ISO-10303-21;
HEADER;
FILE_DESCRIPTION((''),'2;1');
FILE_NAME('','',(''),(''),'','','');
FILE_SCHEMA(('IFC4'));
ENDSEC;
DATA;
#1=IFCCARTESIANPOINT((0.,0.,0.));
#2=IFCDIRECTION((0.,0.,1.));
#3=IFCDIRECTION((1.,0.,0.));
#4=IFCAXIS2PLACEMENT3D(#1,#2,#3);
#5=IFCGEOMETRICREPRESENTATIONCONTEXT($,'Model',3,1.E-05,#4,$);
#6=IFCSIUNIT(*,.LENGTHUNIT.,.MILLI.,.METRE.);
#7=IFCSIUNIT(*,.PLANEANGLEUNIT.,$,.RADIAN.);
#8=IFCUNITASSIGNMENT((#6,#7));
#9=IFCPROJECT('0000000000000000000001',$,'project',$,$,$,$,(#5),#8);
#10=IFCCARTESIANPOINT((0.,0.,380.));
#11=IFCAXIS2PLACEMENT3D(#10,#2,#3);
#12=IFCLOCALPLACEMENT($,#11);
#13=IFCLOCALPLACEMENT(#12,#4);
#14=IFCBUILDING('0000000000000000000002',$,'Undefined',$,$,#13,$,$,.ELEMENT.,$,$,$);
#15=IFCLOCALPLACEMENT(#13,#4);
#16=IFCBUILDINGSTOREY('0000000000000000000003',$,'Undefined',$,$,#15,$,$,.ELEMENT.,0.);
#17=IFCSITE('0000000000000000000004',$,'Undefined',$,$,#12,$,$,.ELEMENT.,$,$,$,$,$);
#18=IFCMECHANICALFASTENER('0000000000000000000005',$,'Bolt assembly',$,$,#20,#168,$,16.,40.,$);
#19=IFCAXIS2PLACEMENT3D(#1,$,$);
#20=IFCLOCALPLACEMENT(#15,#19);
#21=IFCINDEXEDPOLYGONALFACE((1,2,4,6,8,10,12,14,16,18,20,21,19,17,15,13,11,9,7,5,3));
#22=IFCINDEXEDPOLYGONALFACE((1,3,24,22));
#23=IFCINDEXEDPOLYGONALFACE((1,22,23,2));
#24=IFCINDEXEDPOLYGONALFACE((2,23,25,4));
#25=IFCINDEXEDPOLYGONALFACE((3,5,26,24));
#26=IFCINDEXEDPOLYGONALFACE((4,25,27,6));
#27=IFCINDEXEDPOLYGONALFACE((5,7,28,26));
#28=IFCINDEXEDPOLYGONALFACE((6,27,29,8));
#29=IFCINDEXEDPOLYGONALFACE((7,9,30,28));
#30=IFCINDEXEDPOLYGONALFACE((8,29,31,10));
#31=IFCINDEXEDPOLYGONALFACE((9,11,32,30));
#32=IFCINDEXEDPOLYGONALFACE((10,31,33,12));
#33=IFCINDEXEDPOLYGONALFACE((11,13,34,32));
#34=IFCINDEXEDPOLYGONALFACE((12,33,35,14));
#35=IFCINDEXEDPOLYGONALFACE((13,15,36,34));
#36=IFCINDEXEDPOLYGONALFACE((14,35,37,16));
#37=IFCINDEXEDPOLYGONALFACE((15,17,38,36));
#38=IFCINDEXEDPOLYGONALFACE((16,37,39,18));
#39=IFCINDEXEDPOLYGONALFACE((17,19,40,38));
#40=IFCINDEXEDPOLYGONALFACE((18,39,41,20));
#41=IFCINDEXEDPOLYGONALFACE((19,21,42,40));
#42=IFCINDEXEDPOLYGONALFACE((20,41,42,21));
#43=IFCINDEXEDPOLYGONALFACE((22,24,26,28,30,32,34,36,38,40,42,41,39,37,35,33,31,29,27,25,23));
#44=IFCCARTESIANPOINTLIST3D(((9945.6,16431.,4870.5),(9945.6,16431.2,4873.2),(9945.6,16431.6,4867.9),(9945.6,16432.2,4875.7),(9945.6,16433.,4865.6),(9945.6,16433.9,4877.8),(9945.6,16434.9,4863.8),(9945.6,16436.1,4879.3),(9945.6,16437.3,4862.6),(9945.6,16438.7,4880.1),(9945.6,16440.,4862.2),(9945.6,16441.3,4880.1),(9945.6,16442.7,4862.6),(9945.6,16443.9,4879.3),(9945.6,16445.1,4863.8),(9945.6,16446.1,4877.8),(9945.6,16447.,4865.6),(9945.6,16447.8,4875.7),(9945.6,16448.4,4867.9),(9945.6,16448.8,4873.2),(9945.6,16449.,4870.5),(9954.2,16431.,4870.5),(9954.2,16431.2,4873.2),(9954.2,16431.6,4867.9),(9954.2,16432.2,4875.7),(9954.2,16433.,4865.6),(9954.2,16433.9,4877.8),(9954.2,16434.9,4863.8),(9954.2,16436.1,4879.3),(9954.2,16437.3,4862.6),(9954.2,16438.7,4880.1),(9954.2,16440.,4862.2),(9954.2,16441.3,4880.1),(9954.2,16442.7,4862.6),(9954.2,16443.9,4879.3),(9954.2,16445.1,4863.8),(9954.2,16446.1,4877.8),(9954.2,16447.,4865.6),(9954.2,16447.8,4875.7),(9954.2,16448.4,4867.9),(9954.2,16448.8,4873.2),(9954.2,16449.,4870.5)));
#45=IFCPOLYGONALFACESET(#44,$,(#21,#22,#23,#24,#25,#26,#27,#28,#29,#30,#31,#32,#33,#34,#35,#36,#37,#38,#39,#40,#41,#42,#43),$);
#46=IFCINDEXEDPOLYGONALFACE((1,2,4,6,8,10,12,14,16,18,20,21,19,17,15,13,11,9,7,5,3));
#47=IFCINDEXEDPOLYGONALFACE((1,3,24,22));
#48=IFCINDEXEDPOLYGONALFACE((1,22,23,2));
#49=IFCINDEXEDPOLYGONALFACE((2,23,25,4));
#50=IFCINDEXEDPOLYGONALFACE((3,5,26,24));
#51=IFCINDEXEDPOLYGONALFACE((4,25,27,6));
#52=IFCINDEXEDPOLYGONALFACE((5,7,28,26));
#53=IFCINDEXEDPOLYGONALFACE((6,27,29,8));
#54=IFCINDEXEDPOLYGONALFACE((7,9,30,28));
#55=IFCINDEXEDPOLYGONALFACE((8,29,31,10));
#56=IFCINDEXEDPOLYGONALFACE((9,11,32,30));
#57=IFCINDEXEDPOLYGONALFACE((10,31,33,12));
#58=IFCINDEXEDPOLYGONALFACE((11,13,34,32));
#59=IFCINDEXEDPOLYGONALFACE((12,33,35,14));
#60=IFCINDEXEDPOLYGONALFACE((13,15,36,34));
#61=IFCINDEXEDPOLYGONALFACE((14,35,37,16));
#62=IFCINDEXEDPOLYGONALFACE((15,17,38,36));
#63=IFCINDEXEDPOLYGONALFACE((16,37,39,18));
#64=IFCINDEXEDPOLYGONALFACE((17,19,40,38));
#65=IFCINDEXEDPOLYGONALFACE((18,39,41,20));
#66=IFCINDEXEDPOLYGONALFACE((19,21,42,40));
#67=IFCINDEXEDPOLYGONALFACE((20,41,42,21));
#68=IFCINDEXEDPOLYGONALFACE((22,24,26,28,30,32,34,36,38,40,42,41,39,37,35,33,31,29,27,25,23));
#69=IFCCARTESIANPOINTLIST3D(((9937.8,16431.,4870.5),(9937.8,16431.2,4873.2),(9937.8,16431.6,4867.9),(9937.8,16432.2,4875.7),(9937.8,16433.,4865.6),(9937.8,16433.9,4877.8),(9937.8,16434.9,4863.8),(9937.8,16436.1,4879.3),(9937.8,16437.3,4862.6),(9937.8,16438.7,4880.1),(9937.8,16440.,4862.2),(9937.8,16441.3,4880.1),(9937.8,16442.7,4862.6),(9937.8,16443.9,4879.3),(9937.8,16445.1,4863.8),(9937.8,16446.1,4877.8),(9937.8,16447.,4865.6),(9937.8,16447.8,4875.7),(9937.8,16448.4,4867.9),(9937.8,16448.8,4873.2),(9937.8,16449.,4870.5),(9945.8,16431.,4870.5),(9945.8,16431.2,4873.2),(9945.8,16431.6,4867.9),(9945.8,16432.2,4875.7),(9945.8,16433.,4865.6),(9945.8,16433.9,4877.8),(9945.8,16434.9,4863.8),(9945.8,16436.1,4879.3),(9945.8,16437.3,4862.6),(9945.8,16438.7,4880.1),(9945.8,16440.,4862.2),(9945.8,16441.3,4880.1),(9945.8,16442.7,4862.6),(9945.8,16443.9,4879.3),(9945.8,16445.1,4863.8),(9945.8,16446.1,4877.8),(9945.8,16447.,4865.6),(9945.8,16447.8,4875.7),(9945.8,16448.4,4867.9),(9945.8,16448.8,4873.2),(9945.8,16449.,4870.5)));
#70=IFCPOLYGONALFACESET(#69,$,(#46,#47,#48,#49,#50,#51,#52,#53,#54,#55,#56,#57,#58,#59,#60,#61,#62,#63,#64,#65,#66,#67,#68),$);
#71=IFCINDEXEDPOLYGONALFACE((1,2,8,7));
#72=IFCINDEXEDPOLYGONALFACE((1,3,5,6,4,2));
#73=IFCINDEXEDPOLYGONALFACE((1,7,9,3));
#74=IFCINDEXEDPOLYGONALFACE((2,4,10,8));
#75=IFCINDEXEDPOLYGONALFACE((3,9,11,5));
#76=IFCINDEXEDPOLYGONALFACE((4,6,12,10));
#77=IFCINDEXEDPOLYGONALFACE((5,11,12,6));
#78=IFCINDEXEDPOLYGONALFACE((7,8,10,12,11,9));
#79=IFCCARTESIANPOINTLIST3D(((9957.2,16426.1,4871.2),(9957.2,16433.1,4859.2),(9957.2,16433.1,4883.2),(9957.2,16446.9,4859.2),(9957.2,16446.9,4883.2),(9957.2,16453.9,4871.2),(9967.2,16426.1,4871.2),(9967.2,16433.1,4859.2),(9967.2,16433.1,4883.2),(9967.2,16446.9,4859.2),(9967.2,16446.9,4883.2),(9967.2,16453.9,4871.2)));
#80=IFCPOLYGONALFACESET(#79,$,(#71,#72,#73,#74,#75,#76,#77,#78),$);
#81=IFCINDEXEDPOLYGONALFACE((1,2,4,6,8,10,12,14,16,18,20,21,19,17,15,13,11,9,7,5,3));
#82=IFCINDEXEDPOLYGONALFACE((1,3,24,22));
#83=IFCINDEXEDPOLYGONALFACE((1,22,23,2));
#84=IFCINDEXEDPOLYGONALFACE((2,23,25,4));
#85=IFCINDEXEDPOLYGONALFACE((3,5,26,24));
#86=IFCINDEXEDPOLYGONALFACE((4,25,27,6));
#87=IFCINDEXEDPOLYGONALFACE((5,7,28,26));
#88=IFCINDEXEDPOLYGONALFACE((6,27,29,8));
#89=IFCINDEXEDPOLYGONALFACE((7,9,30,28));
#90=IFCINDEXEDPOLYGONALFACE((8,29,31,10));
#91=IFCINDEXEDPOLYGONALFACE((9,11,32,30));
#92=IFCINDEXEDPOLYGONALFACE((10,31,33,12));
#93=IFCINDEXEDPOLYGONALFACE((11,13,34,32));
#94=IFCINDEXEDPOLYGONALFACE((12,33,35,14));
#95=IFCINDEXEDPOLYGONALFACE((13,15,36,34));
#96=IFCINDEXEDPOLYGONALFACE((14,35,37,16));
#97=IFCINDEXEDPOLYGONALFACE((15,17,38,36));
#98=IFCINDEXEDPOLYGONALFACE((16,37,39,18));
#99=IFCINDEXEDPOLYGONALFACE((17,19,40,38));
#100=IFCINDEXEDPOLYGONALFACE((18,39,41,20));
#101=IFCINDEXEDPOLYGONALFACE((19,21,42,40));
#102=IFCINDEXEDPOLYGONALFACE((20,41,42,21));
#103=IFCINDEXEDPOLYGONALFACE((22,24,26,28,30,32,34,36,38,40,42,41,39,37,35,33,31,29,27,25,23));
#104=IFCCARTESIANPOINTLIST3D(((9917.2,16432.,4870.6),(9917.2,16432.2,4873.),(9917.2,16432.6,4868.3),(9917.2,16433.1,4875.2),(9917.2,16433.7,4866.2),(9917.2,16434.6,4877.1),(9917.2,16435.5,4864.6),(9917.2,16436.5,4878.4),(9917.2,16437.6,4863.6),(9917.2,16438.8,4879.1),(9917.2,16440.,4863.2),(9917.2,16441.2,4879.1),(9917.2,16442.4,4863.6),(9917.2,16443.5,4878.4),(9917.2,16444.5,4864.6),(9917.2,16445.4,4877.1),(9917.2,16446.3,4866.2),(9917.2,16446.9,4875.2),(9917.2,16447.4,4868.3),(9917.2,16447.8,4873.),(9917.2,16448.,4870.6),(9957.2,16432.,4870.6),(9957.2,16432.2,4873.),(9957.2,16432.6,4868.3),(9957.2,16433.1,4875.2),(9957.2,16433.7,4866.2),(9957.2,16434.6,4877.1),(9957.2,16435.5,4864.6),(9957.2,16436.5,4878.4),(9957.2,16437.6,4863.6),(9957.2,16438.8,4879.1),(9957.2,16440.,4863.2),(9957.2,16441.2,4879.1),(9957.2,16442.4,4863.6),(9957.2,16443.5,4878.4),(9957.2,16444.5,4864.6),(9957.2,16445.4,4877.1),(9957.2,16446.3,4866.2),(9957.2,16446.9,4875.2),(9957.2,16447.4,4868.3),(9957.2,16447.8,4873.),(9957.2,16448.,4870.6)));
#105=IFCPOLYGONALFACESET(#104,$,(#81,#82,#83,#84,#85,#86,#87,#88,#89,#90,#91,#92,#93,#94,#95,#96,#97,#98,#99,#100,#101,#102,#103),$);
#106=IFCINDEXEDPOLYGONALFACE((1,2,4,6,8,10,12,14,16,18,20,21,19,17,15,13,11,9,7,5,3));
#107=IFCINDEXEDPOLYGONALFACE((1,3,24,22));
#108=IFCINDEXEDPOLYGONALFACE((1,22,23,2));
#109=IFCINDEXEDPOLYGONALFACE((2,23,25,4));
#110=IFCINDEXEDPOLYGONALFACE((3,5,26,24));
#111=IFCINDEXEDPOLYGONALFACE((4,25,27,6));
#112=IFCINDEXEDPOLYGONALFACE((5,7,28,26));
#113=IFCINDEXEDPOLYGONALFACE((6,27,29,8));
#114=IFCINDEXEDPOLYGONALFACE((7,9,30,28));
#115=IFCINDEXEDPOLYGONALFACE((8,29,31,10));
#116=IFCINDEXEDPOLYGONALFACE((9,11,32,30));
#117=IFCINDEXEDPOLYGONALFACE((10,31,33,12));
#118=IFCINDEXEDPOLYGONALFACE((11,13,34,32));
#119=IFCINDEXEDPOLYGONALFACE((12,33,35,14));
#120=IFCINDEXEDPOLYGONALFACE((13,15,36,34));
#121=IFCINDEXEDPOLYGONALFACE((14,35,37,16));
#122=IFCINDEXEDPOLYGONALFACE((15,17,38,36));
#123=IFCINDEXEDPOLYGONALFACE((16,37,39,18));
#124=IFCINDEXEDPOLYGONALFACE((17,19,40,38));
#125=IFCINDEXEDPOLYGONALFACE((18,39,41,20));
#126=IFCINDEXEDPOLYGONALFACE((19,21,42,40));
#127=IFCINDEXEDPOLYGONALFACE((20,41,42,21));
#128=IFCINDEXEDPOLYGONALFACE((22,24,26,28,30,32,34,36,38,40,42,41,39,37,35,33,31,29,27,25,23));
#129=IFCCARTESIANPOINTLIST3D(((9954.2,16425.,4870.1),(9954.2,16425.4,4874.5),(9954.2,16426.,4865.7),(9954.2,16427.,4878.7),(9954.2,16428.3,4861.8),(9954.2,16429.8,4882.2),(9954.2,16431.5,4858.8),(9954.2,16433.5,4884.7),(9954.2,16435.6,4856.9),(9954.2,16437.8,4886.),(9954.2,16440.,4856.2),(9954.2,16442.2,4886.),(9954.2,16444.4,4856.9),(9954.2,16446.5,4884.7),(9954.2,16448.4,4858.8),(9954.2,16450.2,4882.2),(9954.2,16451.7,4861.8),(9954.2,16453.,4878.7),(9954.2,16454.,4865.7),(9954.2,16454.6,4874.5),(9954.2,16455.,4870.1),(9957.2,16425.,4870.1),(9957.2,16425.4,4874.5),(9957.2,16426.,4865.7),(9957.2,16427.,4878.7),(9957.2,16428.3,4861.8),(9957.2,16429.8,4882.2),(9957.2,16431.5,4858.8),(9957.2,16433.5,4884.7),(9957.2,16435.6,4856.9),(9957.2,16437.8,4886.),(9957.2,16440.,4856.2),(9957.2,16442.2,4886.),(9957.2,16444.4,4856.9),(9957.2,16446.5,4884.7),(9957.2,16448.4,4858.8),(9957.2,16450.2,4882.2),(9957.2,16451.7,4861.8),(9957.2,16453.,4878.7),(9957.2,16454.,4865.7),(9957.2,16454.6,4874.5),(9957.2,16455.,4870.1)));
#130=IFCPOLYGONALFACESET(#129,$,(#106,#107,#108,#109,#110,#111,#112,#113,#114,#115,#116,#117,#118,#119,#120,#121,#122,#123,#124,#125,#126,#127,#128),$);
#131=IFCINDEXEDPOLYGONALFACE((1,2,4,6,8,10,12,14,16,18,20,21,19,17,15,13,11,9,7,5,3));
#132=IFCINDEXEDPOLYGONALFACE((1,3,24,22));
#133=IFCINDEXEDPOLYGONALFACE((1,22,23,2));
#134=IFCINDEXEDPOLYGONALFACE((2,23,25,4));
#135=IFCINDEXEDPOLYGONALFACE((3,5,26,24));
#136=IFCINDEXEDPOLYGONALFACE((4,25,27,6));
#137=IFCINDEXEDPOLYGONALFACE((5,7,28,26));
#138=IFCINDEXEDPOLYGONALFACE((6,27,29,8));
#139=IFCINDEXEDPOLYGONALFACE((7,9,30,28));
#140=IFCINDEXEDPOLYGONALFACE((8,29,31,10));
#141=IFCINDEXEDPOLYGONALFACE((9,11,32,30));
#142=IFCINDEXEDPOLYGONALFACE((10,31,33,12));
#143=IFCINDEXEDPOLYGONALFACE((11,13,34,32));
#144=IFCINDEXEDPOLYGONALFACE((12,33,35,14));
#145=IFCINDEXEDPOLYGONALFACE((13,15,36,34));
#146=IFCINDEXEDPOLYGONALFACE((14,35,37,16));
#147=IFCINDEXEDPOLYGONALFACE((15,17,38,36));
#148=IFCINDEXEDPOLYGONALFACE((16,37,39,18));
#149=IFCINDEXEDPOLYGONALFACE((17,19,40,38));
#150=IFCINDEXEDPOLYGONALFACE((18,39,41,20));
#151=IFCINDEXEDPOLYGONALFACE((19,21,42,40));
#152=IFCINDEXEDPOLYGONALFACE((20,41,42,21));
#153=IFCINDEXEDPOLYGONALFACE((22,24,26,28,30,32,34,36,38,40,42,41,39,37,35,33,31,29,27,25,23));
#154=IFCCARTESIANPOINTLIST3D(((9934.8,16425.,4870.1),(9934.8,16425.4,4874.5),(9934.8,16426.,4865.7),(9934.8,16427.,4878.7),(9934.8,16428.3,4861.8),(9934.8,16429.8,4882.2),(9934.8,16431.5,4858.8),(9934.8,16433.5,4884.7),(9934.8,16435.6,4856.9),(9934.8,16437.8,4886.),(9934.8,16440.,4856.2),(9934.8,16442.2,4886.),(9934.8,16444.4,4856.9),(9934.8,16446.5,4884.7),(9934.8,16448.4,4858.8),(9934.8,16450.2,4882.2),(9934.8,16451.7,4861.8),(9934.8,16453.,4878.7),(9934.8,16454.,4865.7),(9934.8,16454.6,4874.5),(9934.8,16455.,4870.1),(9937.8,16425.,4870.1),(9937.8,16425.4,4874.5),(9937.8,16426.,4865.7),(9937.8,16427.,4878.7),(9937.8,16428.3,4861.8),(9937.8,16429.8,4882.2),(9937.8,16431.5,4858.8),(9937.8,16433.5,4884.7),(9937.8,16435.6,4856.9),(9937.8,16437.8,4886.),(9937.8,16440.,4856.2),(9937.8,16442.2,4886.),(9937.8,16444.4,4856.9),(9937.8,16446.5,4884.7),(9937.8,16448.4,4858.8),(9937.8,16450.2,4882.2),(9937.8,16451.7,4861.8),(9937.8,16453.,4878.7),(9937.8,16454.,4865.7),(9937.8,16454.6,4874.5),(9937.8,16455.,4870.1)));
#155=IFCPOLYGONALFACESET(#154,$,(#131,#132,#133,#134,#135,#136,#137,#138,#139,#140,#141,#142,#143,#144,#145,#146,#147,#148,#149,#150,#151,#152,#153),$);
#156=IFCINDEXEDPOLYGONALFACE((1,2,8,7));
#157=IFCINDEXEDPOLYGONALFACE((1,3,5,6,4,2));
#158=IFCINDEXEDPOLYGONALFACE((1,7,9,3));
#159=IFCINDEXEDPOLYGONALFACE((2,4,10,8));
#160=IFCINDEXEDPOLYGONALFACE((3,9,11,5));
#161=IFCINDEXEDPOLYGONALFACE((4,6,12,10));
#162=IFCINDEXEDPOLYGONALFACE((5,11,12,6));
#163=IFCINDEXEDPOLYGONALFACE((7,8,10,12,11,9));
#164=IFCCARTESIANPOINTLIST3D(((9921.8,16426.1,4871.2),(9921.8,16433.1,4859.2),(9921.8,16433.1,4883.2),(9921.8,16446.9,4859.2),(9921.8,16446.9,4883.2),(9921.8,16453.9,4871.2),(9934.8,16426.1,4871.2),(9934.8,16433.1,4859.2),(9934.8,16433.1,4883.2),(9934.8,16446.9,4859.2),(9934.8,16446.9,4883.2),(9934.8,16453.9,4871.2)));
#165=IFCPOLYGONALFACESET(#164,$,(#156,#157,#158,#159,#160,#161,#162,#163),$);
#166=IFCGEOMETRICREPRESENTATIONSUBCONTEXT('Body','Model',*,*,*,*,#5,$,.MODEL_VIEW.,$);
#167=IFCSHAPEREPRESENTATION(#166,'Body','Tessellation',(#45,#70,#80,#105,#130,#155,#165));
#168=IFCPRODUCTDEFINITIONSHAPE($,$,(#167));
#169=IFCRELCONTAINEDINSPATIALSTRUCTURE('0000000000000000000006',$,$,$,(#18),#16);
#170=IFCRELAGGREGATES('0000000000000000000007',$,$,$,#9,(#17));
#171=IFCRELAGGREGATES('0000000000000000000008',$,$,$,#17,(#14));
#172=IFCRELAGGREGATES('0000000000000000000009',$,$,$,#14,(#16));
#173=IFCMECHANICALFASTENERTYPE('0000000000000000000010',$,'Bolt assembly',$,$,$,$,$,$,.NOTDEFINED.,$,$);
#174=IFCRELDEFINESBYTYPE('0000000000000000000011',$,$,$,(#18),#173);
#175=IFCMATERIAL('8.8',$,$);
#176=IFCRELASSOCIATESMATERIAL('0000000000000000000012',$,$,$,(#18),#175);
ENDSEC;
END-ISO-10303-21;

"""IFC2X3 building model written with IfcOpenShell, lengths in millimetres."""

from ifc_helpers import new_model, si_unit, frame, origin_with_axes, origin_2d_with_axis, place, context, subcontext, project, spatial, polyline, circle, outline, extrude, source, transform, mapped, material, type_object, element, save


model = new_model("IFC2X3")

# Units and contexts
model_context = context("Model", 3, precision=1e-05, world=origin_with_axes())
body_context = subcontext(model_context, "Body", "Model", "MODEL_VIEW")
ifc_project = project(units=[si_unit("LENGTHUNIT", "METRE", prefix="MILLI"), si_unit("PLANEANGLEUNIT", "RADIAN")], contexts=[model_context])

# Site, building, storey
site_placement = place(None, frame((0.0, 0.0, 380.0), z_axis=(0.0, 0.0, 1.0), x_axis=(1.0, 0.0, 0.0)))
site = spatial("IfcSite", under=ifc_project, at=site_placement, Name="Undefined", CompositionType="ELEMENT")
building_placement = place(site_placement, origin_with_axes())
building = spatial("IfcBuilding", under=site, at=building_placement, Name="Undefined", CompositionType="ELEMENT")
storey_placement = place(building_placement, origin_with_axes())
storey = spatial("IfcBuildingStorey", under=building, at=storey_placement, Name="Undefined", CompositionType="ELEMENT", Elevation=0.0)

# Mechanical fastener
ifc_material_1 = material(Name="8.8")
mechanical_fastener_type = type_object("IfcMechanicalFastenerType", Name="Bolt assembly")
shared_shape_1 = source(origin_with_axes(), body_context, "Body", "SweptSolid", [
    extrude(circle(Radius=9.0, at=origin_2d_with_axis()), frame((0.0, -8.4, 0.0), z_axis=(0.0, 1.0, 0.0), x_axis=(1.0, 0.0, 0.0)), (0.0, 0.0, 1.0), 8.5),
    extrude(circle(Radius=9.0, at=origin_2d_with_axis()), frame((0.0, -0.1, 0.0), z_axis=(0.0, 1.0, 0.0), x_axis=(1.0, 0.0, 0.0)), (0.0, 0.0, 1.0), 8.1),
    extrude(outline(polyline([(12.0, -6.9), (12.0, 6.9), (0.0, 13.9), (-12.0, 6.9), (-12.0, -6.9), (0.0, -13.9), (12.0, -6.9)])), frame((0.0, -21.5, 0.0), z_axis=(0.0, 1.0, 0.0), x_axis=(1.0, 0.0, 0.0)), (0.0, 0.0, 1.0), 10.0),
    extrude(circle(Radius=8.0, at=origin_2d_with_axis()), frame((0.0, -11.5, 0.0), z_axis=(0.0, 1.0, 0.0), x_axis=(1.0, 0.0, 0.0)), (0.0, 0.0, 1.0), 40.0),
    extrude(circle(Radius=15.0, at=origin_2d_with_axis()), frame((0.0, -11.5, 0.0), z_axis=(0.0, 1.0, 0.0), x_axis=(1.0, 0.0, 0.0)), (0.0, 0.0, 1.0), 3.0),
    extrude(circle(Radius=15.0, at=origin_2d_with_axis()), frame((0.0, 8.0, 0.0), z_axis=(0.0, 1.0, 0.0), x_axis=(1.0, 0.0, 0.0)), (0.0, 0.0, 1.0), 3.0),
    extrude(outline(polyline([(12.0, -6.9), (12.0, 6.9), (0.0, 13.9), (-12.0, 6.9), (-12.0, -6.9), (0.0, -13.9), (12.0, -6.9)])), frame((0.0, 11.0, 0.0), z_axis=(0.0, 1.0, 0.0), x_axis=(1.0, 0.0, 0.0)), (0.0, 0.0, 1.0), 13.0),
])
for number, where, z_axis, x_axis, name in (
    (1, (9945.8, 16402.5, 4951.2), (0.0, 1.0, 0.0), (0.0, 0.0, -1.0), "Bolt assembly"),
):
    element("IfcMechanicalFastener", number, at=place(storey_placement, frame(where, z_axis=z_axis, x_axis=x_axis)), inside=storey, type_object=mechanical_fastener_type, material=ifc_material_1, Name=name, NominalDiameter=16.0, NominalLength=40.0, context=body_context, shape_type="MappedRepresentation", body=[
        mapped(shared_shape_1, transform((80.0, 0.0, 37.5))),
    ])

save(model, "model.ifc")
